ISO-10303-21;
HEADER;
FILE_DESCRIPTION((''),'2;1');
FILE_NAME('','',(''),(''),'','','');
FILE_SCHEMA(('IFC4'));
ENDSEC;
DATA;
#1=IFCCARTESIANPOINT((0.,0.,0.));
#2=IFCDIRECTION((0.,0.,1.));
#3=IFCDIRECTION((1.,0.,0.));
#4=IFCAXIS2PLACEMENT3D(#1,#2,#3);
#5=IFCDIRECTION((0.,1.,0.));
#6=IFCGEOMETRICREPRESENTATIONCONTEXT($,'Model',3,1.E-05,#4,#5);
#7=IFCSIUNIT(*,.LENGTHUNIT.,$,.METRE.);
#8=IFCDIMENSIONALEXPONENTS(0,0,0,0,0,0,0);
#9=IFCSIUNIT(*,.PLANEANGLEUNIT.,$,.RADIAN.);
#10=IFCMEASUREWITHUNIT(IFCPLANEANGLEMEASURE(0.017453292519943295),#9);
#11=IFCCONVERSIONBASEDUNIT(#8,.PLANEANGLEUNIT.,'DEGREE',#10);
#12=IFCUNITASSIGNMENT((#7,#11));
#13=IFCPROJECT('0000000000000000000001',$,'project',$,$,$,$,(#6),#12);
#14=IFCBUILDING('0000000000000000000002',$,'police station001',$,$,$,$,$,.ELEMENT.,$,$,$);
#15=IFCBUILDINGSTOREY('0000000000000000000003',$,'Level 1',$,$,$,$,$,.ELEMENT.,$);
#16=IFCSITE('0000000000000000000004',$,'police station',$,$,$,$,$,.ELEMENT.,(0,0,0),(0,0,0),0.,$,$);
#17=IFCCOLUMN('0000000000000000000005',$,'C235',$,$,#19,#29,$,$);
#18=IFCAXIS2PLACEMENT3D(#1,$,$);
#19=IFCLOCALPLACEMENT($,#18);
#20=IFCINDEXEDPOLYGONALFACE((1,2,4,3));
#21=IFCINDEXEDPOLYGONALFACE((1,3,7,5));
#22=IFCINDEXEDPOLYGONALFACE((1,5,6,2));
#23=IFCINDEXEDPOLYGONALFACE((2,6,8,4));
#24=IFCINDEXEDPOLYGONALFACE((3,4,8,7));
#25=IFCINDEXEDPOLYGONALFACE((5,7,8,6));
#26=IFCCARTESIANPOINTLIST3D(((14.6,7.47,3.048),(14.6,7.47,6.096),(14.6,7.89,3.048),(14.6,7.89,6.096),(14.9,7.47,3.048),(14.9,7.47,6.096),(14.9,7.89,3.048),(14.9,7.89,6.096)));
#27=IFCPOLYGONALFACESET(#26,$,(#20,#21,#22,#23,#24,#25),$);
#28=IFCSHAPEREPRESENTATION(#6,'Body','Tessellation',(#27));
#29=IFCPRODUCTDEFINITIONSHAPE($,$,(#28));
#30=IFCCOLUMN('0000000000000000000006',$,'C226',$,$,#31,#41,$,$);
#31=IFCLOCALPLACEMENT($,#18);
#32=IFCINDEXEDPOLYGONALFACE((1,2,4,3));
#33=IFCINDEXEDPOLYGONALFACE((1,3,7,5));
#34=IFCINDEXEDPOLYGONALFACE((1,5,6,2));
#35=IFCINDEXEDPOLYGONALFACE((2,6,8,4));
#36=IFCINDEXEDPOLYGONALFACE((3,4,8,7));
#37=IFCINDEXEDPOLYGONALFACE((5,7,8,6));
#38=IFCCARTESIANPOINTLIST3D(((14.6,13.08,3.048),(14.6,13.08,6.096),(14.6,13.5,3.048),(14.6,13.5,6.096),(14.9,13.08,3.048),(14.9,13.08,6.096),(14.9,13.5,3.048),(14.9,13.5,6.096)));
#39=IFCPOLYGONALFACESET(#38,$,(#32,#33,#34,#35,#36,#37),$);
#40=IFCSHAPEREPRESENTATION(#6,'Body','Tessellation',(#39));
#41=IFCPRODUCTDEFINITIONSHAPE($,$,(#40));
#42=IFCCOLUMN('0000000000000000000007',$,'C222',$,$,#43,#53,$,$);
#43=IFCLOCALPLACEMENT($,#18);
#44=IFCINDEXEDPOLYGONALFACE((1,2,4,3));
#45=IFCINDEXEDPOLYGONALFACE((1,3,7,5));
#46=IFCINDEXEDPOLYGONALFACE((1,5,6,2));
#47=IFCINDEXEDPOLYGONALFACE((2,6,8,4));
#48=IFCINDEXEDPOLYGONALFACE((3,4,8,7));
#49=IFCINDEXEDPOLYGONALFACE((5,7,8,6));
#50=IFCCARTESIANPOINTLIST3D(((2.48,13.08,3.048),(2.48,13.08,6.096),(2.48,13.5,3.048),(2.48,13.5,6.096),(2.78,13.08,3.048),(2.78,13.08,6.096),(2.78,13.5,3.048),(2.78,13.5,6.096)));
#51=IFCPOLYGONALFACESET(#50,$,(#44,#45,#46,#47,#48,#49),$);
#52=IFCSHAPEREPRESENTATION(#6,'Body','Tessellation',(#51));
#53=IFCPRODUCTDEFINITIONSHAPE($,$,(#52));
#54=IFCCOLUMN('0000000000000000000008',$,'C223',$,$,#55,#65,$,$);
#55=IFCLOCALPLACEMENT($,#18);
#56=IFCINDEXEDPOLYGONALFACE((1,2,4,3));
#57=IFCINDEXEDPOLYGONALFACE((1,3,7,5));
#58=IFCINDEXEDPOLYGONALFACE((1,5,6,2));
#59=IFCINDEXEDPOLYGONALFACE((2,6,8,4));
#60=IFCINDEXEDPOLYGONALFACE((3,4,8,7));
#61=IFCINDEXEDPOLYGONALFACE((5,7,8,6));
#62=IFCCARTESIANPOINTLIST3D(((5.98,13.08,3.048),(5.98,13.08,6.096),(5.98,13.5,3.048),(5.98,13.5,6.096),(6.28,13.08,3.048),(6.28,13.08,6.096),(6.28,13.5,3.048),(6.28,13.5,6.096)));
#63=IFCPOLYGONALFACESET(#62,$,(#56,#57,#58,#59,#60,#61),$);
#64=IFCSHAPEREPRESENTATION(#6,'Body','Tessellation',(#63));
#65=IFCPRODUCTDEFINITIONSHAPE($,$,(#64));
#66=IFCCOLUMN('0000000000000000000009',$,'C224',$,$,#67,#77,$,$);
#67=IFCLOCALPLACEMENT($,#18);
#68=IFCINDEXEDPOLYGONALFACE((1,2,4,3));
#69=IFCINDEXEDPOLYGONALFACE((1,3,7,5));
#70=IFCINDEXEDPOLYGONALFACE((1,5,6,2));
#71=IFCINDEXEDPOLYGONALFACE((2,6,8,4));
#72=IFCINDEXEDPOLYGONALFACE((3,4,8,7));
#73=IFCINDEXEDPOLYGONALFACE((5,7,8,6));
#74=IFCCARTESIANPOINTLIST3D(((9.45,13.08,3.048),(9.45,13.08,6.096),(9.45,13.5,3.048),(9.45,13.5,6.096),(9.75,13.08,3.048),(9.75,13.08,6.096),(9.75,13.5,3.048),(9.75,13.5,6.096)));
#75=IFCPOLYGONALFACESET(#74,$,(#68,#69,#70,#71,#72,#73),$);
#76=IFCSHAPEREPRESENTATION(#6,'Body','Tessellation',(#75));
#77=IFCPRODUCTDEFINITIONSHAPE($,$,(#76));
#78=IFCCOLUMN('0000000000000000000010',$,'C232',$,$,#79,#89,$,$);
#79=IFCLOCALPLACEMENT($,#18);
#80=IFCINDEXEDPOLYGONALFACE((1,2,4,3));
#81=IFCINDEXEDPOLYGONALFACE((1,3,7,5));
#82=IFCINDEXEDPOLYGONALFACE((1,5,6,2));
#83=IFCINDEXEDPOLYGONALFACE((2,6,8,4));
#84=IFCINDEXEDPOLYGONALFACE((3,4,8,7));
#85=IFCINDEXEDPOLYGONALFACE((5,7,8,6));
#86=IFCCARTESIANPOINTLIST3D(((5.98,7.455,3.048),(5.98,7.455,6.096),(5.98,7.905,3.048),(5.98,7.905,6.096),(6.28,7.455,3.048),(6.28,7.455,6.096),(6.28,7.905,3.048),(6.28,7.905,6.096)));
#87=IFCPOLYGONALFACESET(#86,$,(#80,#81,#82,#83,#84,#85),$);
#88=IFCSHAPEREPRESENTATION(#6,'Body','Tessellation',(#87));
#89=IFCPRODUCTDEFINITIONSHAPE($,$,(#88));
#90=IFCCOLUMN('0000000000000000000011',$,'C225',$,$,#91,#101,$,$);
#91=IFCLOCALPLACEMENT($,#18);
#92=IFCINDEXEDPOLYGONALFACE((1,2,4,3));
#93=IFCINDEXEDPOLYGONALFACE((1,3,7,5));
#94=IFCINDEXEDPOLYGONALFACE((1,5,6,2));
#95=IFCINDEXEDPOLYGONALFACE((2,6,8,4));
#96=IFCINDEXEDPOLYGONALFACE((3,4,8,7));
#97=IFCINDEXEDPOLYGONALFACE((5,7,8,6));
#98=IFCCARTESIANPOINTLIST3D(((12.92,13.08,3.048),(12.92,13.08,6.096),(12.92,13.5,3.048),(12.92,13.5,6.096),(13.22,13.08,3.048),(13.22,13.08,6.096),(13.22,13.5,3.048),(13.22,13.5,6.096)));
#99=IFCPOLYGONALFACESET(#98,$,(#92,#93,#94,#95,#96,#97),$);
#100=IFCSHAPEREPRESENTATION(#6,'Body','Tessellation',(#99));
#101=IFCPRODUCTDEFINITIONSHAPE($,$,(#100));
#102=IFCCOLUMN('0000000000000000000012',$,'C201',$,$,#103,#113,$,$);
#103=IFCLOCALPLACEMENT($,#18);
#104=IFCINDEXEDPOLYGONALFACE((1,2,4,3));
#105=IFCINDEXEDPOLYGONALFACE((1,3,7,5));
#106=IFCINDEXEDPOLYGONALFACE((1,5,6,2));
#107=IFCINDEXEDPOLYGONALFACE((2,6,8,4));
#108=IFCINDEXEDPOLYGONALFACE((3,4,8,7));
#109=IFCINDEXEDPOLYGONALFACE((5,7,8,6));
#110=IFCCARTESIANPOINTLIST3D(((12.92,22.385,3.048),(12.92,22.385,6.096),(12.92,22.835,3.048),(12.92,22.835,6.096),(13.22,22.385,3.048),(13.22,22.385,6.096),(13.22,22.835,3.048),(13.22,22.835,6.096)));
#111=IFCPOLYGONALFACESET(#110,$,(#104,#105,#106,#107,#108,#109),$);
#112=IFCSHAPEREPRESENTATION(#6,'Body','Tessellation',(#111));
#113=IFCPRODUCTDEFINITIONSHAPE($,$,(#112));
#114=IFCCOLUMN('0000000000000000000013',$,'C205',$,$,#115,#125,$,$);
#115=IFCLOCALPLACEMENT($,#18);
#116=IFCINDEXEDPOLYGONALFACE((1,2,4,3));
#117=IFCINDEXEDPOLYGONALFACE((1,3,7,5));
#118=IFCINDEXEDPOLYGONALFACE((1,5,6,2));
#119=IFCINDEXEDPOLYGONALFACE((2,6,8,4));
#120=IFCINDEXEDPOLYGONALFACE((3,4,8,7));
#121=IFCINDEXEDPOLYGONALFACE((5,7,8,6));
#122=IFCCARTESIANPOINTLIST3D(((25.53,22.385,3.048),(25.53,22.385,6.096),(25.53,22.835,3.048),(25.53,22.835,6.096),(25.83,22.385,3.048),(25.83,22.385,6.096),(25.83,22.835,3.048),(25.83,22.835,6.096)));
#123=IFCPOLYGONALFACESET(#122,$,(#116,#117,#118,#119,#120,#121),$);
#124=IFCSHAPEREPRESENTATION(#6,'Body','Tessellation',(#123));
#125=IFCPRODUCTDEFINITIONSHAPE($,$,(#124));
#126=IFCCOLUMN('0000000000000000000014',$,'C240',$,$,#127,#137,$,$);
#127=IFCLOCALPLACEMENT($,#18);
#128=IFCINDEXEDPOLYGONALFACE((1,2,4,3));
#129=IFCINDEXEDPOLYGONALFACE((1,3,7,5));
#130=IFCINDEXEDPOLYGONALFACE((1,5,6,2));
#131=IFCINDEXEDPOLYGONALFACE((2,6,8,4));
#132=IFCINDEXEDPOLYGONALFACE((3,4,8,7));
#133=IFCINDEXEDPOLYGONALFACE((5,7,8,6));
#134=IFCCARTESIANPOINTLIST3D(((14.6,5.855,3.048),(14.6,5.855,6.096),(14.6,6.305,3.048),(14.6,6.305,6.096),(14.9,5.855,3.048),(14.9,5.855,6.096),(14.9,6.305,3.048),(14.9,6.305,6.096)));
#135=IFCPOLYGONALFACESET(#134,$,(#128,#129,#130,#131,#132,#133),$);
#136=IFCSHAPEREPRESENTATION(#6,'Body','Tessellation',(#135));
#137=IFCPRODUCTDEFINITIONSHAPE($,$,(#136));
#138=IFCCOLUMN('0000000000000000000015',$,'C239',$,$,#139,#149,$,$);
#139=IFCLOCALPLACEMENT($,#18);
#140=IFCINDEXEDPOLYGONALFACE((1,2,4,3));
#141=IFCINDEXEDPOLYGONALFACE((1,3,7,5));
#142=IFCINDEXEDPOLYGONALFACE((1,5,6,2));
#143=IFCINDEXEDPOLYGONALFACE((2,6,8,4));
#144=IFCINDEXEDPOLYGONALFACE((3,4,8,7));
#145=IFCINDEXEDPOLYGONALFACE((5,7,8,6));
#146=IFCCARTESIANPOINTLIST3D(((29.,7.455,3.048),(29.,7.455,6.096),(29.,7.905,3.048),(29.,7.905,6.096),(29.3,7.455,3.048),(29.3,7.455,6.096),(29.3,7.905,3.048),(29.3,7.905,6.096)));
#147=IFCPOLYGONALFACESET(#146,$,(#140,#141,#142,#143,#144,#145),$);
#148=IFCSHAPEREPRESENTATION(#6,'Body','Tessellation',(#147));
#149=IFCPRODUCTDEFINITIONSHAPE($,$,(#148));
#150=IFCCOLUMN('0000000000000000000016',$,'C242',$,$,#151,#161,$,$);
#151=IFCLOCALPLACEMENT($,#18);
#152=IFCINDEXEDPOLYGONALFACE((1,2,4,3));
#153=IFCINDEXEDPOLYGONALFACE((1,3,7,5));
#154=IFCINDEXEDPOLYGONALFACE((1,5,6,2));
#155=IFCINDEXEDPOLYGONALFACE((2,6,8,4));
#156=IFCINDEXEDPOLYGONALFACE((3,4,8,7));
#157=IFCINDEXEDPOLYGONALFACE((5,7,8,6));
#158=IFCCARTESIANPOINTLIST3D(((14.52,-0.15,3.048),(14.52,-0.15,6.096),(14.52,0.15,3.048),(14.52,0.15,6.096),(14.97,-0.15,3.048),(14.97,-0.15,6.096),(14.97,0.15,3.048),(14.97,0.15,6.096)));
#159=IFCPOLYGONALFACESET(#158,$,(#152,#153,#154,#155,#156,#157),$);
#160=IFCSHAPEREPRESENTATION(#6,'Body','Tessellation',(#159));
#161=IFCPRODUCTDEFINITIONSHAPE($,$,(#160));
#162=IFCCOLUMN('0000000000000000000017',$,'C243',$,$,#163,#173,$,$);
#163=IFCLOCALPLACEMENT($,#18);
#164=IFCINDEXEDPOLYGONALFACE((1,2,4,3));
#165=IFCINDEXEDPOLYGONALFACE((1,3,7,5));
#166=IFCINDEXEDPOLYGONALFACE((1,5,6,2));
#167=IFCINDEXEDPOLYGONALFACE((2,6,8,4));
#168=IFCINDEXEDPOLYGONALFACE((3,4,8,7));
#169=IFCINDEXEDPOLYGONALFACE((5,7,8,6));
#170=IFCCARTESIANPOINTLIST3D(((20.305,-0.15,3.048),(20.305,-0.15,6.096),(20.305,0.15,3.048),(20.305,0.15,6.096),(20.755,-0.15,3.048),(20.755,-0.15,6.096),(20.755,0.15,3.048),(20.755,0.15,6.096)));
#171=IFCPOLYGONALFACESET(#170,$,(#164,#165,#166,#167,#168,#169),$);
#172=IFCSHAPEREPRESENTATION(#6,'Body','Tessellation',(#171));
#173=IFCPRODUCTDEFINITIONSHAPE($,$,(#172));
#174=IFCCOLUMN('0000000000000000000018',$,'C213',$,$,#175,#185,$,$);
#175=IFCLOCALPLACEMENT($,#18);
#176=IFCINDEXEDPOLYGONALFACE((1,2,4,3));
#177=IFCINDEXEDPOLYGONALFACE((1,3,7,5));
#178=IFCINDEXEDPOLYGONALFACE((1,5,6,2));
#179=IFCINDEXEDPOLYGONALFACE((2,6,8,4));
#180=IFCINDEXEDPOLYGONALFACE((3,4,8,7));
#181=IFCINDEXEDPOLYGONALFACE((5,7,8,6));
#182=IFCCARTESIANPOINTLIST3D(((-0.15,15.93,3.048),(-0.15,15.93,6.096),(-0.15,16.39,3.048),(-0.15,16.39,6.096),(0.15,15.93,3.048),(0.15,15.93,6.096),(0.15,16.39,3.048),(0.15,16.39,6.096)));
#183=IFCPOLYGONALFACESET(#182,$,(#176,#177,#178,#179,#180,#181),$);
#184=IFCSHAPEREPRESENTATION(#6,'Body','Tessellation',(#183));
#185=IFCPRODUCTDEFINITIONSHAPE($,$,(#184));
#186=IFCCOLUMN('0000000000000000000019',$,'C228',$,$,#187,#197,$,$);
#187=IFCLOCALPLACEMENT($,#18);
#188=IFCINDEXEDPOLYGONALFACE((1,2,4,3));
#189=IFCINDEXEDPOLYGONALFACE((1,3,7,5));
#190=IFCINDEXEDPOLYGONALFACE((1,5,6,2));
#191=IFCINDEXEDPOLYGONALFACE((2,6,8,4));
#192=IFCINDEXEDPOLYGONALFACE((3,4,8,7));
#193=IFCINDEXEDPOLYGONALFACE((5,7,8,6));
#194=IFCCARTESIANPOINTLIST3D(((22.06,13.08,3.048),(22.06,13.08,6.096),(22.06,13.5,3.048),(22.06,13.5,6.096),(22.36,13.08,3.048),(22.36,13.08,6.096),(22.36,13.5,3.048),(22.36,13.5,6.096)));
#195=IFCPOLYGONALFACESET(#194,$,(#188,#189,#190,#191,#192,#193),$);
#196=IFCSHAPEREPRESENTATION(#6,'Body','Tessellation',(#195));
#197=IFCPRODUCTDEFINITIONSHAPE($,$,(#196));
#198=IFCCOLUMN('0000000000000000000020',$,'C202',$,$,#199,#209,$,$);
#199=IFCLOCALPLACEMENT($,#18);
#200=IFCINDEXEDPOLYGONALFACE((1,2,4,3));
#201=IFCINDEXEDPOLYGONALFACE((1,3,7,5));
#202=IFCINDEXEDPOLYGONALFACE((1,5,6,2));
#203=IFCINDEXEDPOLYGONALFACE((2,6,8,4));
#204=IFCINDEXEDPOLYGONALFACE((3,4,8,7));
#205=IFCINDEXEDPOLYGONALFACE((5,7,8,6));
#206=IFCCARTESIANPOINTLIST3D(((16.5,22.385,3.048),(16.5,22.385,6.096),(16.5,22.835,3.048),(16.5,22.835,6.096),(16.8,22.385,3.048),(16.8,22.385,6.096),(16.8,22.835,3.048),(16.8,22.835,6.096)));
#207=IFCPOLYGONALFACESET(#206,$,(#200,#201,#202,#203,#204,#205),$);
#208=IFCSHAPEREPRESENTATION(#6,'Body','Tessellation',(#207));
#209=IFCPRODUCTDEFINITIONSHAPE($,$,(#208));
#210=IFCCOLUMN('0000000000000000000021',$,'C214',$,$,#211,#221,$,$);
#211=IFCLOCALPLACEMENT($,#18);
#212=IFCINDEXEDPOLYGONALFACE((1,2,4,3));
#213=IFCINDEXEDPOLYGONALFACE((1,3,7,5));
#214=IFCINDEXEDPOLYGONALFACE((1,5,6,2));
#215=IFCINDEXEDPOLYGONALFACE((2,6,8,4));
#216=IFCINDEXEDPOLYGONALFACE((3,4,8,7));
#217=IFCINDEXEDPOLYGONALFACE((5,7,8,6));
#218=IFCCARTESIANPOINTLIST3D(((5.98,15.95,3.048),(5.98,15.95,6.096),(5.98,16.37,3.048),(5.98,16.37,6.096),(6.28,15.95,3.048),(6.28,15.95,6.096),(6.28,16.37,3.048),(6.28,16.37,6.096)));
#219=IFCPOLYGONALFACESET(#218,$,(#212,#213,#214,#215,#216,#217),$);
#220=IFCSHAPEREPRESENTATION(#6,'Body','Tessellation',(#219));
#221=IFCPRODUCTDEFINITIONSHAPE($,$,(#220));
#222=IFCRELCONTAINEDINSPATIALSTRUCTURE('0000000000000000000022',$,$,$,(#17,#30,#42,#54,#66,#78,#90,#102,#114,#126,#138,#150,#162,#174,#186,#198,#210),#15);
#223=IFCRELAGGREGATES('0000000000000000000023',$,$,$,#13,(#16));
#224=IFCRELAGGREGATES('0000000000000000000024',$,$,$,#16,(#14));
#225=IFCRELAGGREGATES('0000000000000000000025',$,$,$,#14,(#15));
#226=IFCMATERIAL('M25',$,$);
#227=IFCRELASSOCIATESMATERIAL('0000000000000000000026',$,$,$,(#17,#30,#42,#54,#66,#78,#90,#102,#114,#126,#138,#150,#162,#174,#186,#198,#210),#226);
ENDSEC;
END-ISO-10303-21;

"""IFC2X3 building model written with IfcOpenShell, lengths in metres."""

from ifc_helpers import new_model, entity, si_unit, converted_unit, direction, frame, frame_2d, origin_with_axes, place, context, project, spatial, rectangle, extrude, material, element, save


model = new_model("IFC2X3")

# Units and contexts
model_context = context("Model", 3, precision=1e-05, world=origin_with_axes(), true_north=direction((0.0, 1.0, 0.0)))
ifc_project = project(units=[si_unit("LENGTHUNIT", "METRE"), converted_unit("PLANEANGLEUNIT", "DEGREE", entity("IfcPlaneAngleMeasure", 0.017453292519943295), si_unit("PLANEANGLEUNIT", "RADIAN"), dimensions=[0, 0, 0, 0, 0, 0, 0])], contexts=[model_context])

# Site, building, storey
site = spatial("IfcSite", under=ifc_project, Name="police station", CompositionType="ELEMENT", RefLatitude=(0, 0, 0), RefLongitude=(0, 0, 0), RefElevation=0.0)
building = spatial("IfcBuilding", under=site, Name="police station001", CompositionType="ELEMENT")
storey = spatial("IfcBuildingStorey", under=building, Name="Level 1", CompositionType="ELEMENT")

# Columns
ifc_material = material(Name="M25")
placement = place(None, origin_with_axes())
element("IfcColumn", 1, at=placement, inside=storey, material=ifc_material, Name="C235", context=model_context, shape_type="SweptSolid", body=[
    extrude(rectangle(XDim=0.3, YDim=0.42, at=frame_2d((0.0, 0.0), x_axis=(1.0, 0.0, 0.0))), frame((14.75, 7.68, 3.048), z_axis=(0.0, 0.0, 1.0), x_axis=(1.0, 0.0, 0.0)), (0.0, 0.0, 1.0), 3.048),
])
element("IfcColumn", 2, at=placement, inside=storey, material=ifc_material, Name="C226", context=model_context, shape_type="SweptSolid", body=[
    extrude(rectangle(XDim=0.3, YDim=0.42, at=frame_2d((0.0, 0.0), x_axis=(1.0, 0.0, 0.0))), frame((14.75, 13.29, 3.048), z_axis=(0.0, 0.0, 1.0), x_axis=(1.0, 0.0, 0.0)), (0.0, 0.0, 1.0), 3.048),
])
element("IfcColumn", 3, at=placement, inside=storey, material=ifc_material, Name="C222", context=model_context, shape_type="SweptSolid", body=[
    extrude(rectangle(XDim=0.3, YDim=0.42, at=frame_2d((0.0, 0.0), x_axis=(1.0, 0.0, 0.0))), frame((2.63, 13.29, 3.048), z_axis=(0.0, 0.0, 1.0), x_axis=(1.0, 0.0, 0.0)), (0.0, 0.0, 1.0), 3.048),
])
element("IfcColumn", 4, at=placement, inside=storey, material=ifc_material, Name="C223", context=model_context, shape_type="SweptSolid", body=[
    extrude(rectangle(XDim=0.3, YDim=0.42, at=frame_2d((0.0, 0.0), x_axis=(1.0, 0.0, 0.0))), frame((6.13, 13.29, 3.048), z_axis=(0.0, 0.0, 1.0), x_axis=(1.0, 0.0, 0.0)), (0.0, 0.0, 1.0), 3.048),
])
element("IfcColumn", 5, at=placement, inside=storey, material=ifc_material, Name="C224", context=model_context, shape_type="SweptSolid", body=[
    extrude(rectangle(XDim=0.3, YDim=0.42, at=frame_2d((0.0, 0.0), x_axis=(1.0, 0.0, 0.0))), frame((9.6, 13.29, 3.048), z_axis=(0.0, 0.0, 1.0), x_axis=(1.0, 0.0, 0.0)), (0.0, 0.0, 1.0), 3.048),
])
element("IfcColumn", 6, at=placement, inside=storey, material=ifc_material, Name="C232", context=model_context, shape_type="SweptSolid", body=[
    extrude(rectangle(XDim=0.3, YDim=0.45, at=frame_2d((0.0, 0.0), x_axis=(1.0, 0.0, 0.0))), frame((6.13, 7.68, 3.048), z_axis=(0.0, 0.0, 1.0), x_axis=(1.0, 0.0, 0.0)), (0.0, 0.0, 1.0), 3.048),
])
element("IfcColumn", 7, at=placement, inside=storey, material=ifc_material, Name="C225", context=model_context, shape_type="SweptSolid", body=[
    extrude(rectangle(XDim=0.3, YDim=0.42, at=frame_2d((0.0, 0.0), x_axis=(1.0, 0.0, 0.0))), frame((13.07, 13.29, 3.048), z_axis=(0.0, 0.0, 1.0), x_axis=(1.0, 0.0, 0.0)), (0.0, 0.0, 1.0), 3.048),
])
element("IfcColumn", 8, at=placement, inside=storey, material=ifc_material, Name="C201", context=model_context, shape_type="SweptSolid", body=[
    extrude(rectangle(XDim=0.3, YDim=0.45, at=frame_2d((0.0, 0.0), x_axis=(1.0, 0.0, 0.0))), frame((13.07, 22.61, 3.048), z_axis=(0.0, 0.0, 1.0), x_axis=(1.0, 0.0, 0.0)), (0.0, 0.0, 1.0), 3.048),
])
element("IfcColumn", 9, at=placement, inside=storey, material=ifc_material, Name="C205", context=model_context, shape_type="SweptSolid", body=[
    extrude(rectangle(XDim=0.3, YDim=0.45, at=frame_2d((0.0, 0.0), x_axis=(1.0, 0.0, 0.0))), frame((25.68, 22.61, 3.048), z_axis=(0.0, 0.0, 1.0), x_axis=(1.0, 0.0, 0.0)), (0.0, 0.0, 1.0), 3.048),
])
element("IfcColumn", 10, at=placement, inside=storey, material=ifc_material, Name="C240", context=model_context, shape_type="SweptSolid", body=[
    extrude(rectangle(XDim=0.3, YDim=0.45, at=frame_2d((0.0, 0.0), x_axis=(1.0, 0.0, 0.0))), frame((14.75, 6.08, 3.048), z_axis=(0.0, 0.0, 1.0), x_axis=(1.0, 0.0, 0.0)), (0.0, 0.0, 1.0), 3.048),
])
element("IfcColumn", 11, at=placement, inside=storey, material=ifc_material, Name="C239", context=model_context, shape_type="SweptSolid", body=[
    extrude(rectangle(XDim=0.3, YDim=0.45, at=frame_2d((0.0, 0.0), x_axis=(1.0, 0.0, 0.0))), frame((29.15, 7.68, 3.048), z_axis=(0.0, 0.0, 1.0), x_axis=(1.0, 0.0, 0.0)), (0.0, 0.0, 1.0), 3.048),
])
element("IfcColumn", 12, at=placement, inside=storey, material=ifc_material, Name="C242", context=model_context, shape_type="SweptSolid", body=[
    extrude(rectangle(XDim=0.45, YDim=0.3, at=frame_2d((0.0, 0.0), x_axis=(1.0, 0.0, 0.0))), frame((14.745, 0.0, 3.048), z_axis=(0.0, 0.0, 1.0), x_axis=(1.0, 0.0, 0.0)), (0.0, 0.0, 1.0), 3.048),
])
element("IfcColumn", 13, at=placement, inside=storey, material=ifc_material, Name="C243", context=model_context, shape_type="SweptSolid", body=[
    extrude(rectangle(XDim=0.45, YDim=0.3, at=frame_2d((0.0, 0.0), x_axis=(1.0, 0.0, 0.0))), frame((20.53, 0.0, 3.048), z_axis=(0.0, 0.0, 1.0), x_axis=(1.0, 0.0, 0.0)), (0.0, 0.0, 1.0), 3.048),
])
element("IfcColumn", 14, at=placement, inside=storey, material=ifc_material, Name="C213", context=model_context, shape_type="SweptSolid", body=[
    extrude(rectangle(XDim=0.3, YDim=0.46, at=frame_2d((0.0, 0.0), x_axis=(1.0, 0.0, 0.0))), frame((0.0, 16.16, 3.048), z_axis=(0.0, 0.0, 1.0), x_axis=(1.0, 0.0, 0.0)), (0.0, 0.0, 1.0), 3.048),
])
element("IfcColumn", 15, at=placement, inside=storey, material=ifc_material, Name="C228", context=model_context, shape_type="SweptSolid", body=[
    extrude(rectangle(XDim=0.3, YDim=0.42, at=frame_2d((0.0, 0.0), x_axis=(1.0, 0.0, 0.0))), frame((22.21, 13.29, 3.048), z_axis=(0.0, 0.0, 1.0), x_axis=(1.0, 0.0, 0.0)), (0.0, 0.0, 1.0), 3.048),
])
element("IfcColumn", 16, at=placement, inside=storey, material=ifc_material, Name="C202", context=model_context, shape_type="SweptSolid", body=[
    extrude(rectangle(XDim=0.3, YDim=0.45, at=frame_2d((0.0, 0.0), x_axis=(1.0, 0.0, 0.0))), frame((16.65, 22.61, 3.048), z_axis=(0.0, 0.0, 1.0), x_axis=(1.0, 0.0, 0.0)), (0.0, 0.0, 1.0), 3.048),
])
element("IfcColumn", 17, at=placement, inside=storey, material=ifc_material, Name="C214", context=model_context, shape_type="SweptSolid", body=[
    extrude(rectangle(XDim=0.3, YDim=0.42, at=frame_2d((0.0, 0.0), x_axis=(1.0, 0.0, 0.0))), frame((6.13, 16.16, 3.048), z_axis=(0.0, 0.0, 1.0), x_axis=(1.0, 0.0, 0.0)), (0.0, 0.0, 1.0), 3.048),
])

save(model, "model.ifc")
